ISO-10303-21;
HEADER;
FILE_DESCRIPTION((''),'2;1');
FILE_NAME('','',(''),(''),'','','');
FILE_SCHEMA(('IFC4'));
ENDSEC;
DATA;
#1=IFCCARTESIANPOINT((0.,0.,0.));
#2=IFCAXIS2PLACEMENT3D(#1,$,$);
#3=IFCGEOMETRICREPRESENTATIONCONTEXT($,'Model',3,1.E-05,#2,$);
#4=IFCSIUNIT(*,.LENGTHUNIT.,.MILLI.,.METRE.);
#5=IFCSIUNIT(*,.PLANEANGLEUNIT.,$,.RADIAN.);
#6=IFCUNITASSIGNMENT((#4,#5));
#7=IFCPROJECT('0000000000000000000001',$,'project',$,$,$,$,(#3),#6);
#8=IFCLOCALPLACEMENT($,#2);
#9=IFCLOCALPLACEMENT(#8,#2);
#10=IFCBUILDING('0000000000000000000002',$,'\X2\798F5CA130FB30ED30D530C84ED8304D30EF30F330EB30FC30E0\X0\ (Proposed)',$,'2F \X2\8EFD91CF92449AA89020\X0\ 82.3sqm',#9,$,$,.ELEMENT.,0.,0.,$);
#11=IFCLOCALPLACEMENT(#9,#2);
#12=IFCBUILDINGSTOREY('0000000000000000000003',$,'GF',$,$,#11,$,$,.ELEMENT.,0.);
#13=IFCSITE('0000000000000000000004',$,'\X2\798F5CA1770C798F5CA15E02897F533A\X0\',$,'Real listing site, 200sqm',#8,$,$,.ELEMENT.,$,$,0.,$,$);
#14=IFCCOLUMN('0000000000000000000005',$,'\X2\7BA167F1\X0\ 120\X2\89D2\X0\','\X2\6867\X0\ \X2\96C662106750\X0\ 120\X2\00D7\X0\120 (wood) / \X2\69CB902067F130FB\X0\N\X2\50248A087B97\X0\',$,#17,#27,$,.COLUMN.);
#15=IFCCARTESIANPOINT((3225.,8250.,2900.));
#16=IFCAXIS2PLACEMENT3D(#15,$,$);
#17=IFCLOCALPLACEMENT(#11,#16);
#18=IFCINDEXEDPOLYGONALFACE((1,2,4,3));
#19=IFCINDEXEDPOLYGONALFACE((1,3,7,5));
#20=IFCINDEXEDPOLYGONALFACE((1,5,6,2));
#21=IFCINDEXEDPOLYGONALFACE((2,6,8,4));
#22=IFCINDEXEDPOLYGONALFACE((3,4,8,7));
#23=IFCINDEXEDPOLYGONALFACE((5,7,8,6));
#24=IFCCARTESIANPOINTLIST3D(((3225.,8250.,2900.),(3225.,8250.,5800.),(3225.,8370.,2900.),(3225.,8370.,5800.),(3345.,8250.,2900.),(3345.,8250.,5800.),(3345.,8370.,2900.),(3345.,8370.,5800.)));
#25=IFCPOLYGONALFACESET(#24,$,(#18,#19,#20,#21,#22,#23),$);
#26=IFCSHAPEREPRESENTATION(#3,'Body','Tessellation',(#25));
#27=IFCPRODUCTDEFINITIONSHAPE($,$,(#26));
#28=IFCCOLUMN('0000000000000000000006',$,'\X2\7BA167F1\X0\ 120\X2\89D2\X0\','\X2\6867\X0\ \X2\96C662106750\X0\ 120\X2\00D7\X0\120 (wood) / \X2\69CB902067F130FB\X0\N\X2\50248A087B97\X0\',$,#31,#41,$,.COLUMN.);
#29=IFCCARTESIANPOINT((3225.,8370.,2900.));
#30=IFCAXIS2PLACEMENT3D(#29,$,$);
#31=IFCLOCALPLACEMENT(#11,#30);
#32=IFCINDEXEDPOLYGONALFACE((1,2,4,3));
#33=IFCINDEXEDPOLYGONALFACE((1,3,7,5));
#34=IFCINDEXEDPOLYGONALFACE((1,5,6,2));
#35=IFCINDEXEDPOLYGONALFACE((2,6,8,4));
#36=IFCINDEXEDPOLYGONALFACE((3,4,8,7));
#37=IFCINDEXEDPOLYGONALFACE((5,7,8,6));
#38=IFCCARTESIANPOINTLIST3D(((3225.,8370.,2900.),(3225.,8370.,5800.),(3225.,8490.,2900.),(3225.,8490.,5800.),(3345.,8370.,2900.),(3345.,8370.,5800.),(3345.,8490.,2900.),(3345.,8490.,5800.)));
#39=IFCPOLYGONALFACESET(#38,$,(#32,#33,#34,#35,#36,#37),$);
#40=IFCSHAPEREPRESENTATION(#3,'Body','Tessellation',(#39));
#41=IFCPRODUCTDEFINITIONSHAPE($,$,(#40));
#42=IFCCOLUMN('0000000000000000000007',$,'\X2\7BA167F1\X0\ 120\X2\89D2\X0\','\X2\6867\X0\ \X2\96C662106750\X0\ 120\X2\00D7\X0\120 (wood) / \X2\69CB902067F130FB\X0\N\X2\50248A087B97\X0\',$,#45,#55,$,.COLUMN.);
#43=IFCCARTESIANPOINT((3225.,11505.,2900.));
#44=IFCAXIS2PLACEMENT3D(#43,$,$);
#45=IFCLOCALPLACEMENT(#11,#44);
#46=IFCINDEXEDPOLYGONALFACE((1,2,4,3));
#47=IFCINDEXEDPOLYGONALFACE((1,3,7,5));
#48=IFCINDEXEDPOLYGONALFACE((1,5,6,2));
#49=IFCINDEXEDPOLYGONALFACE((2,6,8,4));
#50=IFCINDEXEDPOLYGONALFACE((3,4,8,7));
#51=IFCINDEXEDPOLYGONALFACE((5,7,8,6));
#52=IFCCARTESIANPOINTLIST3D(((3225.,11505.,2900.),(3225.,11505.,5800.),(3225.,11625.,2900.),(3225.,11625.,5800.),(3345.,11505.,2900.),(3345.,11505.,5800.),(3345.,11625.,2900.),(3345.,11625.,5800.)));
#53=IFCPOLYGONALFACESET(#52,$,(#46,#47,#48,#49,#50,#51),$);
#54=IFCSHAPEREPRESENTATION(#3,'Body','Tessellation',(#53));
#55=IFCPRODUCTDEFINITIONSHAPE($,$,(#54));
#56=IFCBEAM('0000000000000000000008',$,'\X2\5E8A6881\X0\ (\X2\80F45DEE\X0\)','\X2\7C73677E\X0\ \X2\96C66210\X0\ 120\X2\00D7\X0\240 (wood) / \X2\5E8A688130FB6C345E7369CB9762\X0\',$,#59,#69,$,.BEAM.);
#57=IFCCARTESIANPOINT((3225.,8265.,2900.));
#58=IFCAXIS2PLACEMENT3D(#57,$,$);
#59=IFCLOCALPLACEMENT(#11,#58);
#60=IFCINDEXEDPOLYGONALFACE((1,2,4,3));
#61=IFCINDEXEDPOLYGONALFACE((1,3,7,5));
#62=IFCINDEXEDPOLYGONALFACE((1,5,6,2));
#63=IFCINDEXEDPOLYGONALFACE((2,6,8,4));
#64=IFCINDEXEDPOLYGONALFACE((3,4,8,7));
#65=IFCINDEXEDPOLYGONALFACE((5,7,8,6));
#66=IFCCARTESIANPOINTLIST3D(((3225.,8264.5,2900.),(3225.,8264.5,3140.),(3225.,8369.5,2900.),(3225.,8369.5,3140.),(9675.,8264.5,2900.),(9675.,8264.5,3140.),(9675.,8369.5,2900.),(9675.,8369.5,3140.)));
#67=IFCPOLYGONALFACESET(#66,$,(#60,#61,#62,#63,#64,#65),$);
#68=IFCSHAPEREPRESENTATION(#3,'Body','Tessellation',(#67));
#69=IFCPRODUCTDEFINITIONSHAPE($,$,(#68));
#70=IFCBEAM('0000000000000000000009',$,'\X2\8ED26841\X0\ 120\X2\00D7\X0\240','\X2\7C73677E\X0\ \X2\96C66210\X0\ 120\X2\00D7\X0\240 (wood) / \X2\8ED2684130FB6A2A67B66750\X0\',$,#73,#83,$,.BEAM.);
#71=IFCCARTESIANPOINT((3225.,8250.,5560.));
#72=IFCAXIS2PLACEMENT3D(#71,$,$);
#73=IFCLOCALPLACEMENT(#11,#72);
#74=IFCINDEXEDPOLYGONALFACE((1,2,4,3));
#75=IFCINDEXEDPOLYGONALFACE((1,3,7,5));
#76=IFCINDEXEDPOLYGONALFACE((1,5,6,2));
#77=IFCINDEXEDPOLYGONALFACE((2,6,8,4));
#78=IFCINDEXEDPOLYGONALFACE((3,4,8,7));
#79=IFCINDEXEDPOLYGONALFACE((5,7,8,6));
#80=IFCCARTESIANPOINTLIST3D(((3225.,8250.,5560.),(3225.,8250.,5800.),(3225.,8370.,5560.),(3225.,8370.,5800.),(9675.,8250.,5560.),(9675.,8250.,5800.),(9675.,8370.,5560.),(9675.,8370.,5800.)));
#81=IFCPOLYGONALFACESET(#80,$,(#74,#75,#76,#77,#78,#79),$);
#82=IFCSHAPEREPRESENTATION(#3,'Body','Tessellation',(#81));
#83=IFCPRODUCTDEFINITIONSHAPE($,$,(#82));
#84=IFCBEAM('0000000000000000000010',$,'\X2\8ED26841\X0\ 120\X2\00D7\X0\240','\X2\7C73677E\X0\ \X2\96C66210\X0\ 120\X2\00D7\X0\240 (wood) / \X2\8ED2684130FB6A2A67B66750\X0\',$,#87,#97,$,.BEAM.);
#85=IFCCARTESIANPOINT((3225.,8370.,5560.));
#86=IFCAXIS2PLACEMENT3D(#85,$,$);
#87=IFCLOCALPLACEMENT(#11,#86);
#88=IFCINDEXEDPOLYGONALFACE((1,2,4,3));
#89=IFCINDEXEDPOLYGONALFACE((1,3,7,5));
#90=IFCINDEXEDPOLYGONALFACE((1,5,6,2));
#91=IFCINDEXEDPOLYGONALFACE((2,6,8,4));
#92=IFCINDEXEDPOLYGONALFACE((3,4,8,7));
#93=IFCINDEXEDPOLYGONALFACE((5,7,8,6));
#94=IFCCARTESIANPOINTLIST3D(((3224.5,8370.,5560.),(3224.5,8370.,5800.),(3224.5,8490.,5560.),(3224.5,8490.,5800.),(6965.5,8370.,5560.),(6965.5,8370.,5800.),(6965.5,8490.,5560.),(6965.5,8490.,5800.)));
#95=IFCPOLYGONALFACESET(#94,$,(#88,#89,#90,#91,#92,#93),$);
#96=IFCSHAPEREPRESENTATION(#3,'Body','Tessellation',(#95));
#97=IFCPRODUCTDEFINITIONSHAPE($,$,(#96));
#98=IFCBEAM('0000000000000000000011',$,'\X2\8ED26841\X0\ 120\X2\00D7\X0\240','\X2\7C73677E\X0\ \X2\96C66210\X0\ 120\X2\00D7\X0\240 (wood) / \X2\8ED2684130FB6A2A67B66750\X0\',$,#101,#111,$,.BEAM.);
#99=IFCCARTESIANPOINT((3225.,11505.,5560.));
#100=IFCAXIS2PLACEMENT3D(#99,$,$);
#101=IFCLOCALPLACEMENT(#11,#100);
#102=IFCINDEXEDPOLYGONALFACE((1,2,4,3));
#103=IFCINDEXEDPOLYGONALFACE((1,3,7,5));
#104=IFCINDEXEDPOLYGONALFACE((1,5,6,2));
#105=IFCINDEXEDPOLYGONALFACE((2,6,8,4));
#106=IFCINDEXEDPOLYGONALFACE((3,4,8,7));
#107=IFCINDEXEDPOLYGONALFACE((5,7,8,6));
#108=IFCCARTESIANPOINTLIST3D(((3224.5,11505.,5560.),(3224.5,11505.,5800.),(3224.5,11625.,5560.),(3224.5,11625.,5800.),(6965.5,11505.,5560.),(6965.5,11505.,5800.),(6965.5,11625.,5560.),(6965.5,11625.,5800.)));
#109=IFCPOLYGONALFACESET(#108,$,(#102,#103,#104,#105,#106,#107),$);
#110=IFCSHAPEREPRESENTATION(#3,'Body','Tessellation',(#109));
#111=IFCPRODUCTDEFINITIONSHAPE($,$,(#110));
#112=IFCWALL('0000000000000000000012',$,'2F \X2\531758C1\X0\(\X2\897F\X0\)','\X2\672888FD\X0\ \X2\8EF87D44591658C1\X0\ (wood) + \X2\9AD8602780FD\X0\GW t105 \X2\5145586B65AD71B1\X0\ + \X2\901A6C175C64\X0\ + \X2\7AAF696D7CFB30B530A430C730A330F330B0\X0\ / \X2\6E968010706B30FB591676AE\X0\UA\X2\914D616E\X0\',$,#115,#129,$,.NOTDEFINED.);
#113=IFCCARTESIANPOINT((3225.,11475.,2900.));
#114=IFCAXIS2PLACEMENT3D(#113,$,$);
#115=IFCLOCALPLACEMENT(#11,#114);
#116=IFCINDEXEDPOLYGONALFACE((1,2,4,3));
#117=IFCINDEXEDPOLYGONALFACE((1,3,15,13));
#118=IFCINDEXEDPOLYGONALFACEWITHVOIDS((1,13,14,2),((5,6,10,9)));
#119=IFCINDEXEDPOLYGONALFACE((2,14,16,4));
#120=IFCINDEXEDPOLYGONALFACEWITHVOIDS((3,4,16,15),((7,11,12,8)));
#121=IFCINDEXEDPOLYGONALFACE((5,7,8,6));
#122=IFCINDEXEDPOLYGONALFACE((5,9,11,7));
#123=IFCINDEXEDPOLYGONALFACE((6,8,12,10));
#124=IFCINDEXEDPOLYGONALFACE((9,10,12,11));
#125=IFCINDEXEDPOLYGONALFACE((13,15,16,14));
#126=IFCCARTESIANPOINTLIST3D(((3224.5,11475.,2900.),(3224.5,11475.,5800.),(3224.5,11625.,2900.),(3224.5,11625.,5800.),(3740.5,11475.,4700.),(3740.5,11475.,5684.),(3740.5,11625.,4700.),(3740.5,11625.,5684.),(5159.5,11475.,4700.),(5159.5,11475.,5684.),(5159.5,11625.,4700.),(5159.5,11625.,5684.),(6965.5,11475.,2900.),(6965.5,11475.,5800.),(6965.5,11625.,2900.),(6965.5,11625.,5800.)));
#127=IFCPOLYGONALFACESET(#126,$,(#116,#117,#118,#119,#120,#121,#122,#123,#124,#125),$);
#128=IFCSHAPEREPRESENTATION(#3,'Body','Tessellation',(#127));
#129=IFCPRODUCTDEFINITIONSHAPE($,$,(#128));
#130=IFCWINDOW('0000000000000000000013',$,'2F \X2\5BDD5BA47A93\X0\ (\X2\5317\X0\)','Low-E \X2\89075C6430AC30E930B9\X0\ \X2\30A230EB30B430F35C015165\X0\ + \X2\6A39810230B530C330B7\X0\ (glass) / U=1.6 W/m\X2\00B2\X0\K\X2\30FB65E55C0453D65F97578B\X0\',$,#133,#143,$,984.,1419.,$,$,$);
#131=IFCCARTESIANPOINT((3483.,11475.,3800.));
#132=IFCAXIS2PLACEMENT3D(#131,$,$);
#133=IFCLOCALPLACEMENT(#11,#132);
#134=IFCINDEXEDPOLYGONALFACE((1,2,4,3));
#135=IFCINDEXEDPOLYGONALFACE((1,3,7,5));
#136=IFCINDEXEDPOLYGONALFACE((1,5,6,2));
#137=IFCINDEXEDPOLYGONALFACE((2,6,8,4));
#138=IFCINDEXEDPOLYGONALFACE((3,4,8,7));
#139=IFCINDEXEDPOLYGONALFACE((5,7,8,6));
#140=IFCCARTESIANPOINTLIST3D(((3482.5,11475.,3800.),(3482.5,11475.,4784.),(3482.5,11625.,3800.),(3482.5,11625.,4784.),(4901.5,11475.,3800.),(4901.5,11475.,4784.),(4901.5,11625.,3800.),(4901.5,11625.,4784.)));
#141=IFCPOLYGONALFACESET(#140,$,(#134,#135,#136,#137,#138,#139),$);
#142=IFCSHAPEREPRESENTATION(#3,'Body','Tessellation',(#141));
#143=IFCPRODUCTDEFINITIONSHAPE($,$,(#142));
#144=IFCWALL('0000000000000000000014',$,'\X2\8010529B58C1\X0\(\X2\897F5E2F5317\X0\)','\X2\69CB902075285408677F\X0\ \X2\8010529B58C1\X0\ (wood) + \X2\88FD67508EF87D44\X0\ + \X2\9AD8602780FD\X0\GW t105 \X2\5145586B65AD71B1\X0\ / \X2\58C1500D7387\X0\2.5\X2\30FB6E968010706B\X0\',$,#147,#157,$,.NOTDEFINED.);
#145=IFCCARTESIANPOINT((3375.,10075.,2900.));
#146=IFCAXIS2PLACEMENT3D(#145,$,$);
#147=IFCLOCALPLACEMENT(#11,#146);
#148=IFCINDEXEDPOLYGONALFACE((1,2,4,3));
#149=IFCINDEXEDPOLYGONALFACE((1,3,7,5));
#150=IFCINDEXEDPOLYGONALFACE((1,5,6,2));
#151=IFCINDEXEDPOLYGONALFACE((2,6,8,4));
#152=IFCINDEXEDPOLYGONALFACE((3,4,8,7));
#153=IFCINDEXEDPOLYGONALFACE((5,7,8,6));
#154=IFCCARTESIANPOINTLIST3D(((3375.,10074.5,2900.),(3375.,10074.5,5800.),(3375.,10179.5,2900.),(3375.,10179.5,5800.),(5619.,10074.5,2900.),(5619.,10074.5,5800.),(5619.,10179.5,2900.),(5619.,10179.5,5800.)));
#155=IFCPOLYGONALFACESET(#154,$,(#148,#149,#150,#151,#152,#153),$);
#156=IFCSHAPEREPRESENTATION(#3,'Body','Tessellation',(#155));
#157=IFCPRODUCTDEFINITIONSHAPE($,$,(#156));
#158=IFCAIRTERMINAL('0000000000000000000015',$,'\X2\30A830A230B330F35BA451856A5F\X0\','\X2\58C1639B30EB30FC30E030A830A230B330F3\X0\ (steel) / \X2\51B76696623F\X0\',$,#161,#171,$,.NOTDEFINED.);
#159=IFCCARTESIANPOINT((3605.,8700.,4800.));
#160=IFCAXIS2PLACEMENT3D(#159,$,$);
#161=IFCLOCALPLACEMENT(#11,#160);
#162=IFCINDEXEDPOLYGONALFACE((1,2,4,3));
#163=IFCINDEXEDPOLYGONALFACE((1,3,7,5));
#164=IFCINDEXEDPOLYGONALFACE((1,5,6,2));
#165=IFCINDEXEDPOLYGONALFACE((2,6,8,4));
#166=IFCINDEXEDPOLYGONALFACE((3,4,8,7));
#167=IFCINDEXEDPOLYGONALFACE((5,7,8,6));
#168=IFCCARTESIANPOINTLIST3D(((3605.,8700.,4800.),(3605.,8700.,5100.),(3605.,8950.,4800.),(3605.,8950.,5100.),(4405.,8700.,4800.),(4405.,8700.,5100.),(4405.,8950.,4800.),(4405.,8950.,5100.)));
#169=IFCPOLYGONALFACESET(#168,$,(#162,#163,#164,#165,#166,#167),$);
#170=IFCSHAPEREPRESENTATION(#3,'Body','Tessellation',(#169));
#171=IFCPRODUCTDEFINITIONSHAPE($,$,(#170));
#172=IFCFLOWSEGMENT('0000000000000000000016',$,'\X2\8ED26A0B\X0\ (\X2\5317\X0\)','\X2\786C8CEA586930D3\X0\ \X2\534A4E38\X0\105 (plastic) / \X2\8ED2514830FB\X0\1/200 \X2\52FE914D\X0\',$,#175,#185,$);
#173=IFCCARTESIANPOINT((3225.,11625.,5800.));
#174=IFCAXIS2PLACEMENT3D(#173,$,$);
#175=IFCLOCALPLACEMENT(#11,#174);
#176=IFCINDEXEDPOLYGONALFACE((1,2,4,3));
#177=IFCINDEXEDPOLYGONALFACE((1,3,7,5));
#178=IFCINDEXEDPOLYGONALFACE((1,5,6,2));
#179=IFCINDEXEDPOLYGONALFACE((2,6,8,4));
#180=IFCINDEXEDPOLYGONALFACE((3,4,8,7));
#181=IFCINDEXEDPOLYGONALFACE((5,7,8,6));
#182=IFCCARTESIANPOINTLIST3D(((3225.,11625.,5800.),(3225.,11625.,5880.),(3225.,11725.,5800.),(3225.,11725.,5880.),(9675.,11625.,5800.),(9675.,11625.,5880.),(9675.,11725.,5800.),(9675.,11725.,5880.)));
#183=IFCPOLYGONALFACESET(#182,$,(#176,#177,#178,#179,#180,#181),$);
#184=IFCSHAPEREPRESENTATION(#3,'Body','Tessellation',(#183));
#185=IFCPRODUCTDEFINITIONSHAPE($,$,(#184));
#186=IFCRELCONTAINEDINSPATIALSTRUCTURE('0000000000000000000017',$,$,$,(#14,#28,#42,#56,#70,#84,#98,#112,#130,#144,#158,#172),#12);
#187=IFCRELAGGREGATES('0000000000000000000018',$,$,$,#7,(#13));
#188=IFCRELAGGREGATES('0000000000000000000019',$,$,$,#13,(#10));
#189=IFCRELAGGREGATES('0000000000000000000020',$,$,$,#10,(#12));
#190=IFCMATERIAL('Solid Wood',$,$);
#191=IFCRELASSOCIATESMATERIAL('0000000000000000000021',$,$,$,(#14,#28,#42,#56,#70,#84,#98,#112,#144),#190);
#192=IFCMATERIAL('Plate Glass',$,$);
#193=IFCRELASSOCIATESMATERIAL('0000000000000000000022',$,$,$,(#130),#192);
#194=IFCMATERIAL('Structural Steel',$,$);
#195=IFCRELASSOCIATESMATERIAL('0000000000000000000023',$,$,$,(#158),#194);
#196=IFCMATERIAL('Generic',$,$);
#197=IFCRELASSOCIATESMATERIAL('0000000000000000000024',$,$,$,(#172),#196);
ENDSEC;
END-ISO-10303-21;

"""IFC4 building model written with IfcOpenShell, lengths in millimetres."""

from ifc_helpers import new_model, si_unit, frame, frame_2d, origin, place, context, project, spatial, rectangle, extrude, material, element, fill, save


model = new_model("IFC4")

# Units and contexts
model_context = context("Model", 3, precision=1e-05, world=origin())
ifc_project = project(units=[si_unit("LENGTHUNIT", "METRE", prefix="MILLI"), si_unit("PLANEANGLEUNIT", "RADIAN")], contexts=[model_context])

# Site, building, storey
site_placement = place(None, origin())
site = spatial("IfcSite", under=ifc_project, at=site_placement, Name="福岡県福岡市西区", ObjectType="Real listing site, 200sqm", CompositionType="ELEMENT", RefElevation=0.0)
building_placement = place(site_placement, origin())
building = spatial("IfcBuilding", under=site, at=building_placement, Name="福岡・ロフト付きワンルーム (Proposed)", ObjectType="2F 軽量鉄骨造 82.3sqm", CompositionType="ELEMENT", ElevationOfRefHeight=0.0, ElevationOfTerrain=0.0)
storey_placement = place(building_placement, origin())
storey = spatial("IfcBuildingStorey", under=building, at=storey_placement, Name="GF", CompositionType="ELEMENT", Elevation=0.0)

# Columns
ifc_material_1 = material(Name="Solid Wood")
column_1_placement = place(storey_placement, frame((3225.0, 8250.0, 2900.0)))
element("IfcColumn", 1, at=column_1_placement, inside=storey, material=ifc_material_1, Name="管柱 120角", Description="桧 集成材 120×120 (wood) / 構造柱・N値計算", PredefinedType="COLUMN", context=model_context, shape_type="SweptSolid", body=[
    extrude(rectangle(XDim=120.0, YDim=120.0, at=frame_2d((60.0, 60.0))), frame((3225.0, 8250.0, 2900.0)), (0.0, 0.0, 1.0), 2900.0),
])
column_2_placement = place(storey_placement, frame((3225.0, 8370.0, 2900.0)))
element("IfcColumn", 2, at=column_2_placement, inside=storey, material=ifc_material_1, Name="管柱 120角", Description="桧 集成材 120×120 (wood) / 構造柱・N値計算", PredefinedType="COLUMN", context=model_context, shape_type="SweptSolid", body=[
    extrude(rectangle(XDim=120.0, YDim=120.0, at=frame_2d((60.0, 60.0))), frame((3225.0, 8370.0, 2900.0)), (0.0, 0.0, 1.0), 2900.0),
])
column_3_placement = place(storey_placement, frame((3225.0, 11505.0, 2900.0)))
element("IfcColumn", 3, at=column_3_placement, inside=storey, material=ifc_material_1, Name="管柱 120角", Description="桧 集成材 120×120 (wood) / 構造柱・N値計算", PredefinedType="COLUMN", context=model_context, shape_type="SweptSolid", body=[
    extrude(rectangle(XDim=120.0, YDim=120.0, at=frame_2d((60.0, 60.0))), frame((3225.0, 11505.0, 2900.0)), (0.0, 0.0, 1.0), 2900.0),
])

# Beams
beam_1_placement = place(storey_placement, frame((3225.0, 8265.0, 2900.0)))
element("IfcBeam", 4, at=beam_1_placement, inside=storey, material=ifc_material_1, Name="床梁 (胴差)", Description="米松 集成 120×240 (wood) / 床梁・水平構面", PredefinedType="BEAM", context=model_context, shape_type="SweptSolid", body=[
    extrude(rectangle(XDim=6450.0, YDim=105.0, at=frame_2d((3225.0, 52.0))), frame((3225.0, 8265.0, 2900.0)), (0.0, 0.0, 1.0), 240.0),
])
beam_2_placement = place(storey_placement, frame((3225.0, 8250.0, 5560.0)))
element("IfcBeam", 5, at=beam_2_placement, inside=storey, material=ifc_material_1, Name="軒桁 120×240", Description="米松 集成 120×240 (wood) / 軒桁・横架材", PredefinedType="BEAM", context=model_context, shape_type="SweptSolid", body=[
    extrude(rectangle(XDim=6450.0, YDim=120.0, at=frame_2d((3225.0, 60.0))), frame((3225.0, 8250.0, 5560.0)), (0.0, 0.0, 1.0), 240.0),
])
beam_3_placement = place(storey_placement, frame((3225.0, 8370.0, 5560.0)))
element("IfcBeam", 6, at=beam_3_placement, inside=storey, material=ifc_material_1, Name="軒桁 120×240", Description="米松 集成 120×240 (wood) / 軒桁・横架材", PredefinedType="BEAM", context=model_context, shape_type="SweptSolid", body=[
    extrude(rectangle(XDim=3741.0, YDim=120.0, at=frame_2d((1870.0, 60.0))), frame((3225.0, 8370.0, 5560.0)), (0.0, 0.0, 1.0), 240.0),
])
beam_4_placement = place(storey_placement, frame((3225.0, 11505.0, 5560.0)))
element("IfcBeam", 7, at=beam_4_placement, inside=storey, material=ifc_material_1, Name="軒桁 120×240", Description="米松 集成 120×240 (wood) / 軒桁・横架材", PredefinedType="BEAM", context=model_context, shape_type="SweptSolid", body=[
    extrude(rectangle(XDim=3741.0, YDim=120.0, at=frame_2d((1870.0, 60.0))), frame((3225.0, 11505.0, 5560.0)), (0.0, 0.0, 1.0), 240.0),
])

# Wall, opening, window
wall_1_placement = place(storey_placement, frame((3225.0, 11475.0, 2900.0)))
wall_1 = element("IfcWall", 8, at=wall_1_placement, inside=storey, material=ifc_material_1, Name="2F 北壁(西)", Description="木製 軸組外壁 (wood) + 高性能GW t105 充填断熱 + 通気層 + 窯業系サイディング / 準耐火・外皮UA配慮", PredefinedType="NOTDEFINED", context=model_context, shape_type="SweptSolid", body=[
    extrude(rectangle(XDim=3741.0, YDim=150.0, at=frame_2d((1870.0, 75.0))), frame((3225.0, 11475.0, 2900.0)), (0.0, 0.0, 1.0), 2900.0),
])
opening_placement = place(storey_placement, frame((3483.0, 11475.0, 3800.0)))
opening = element("IfcOpeningElement", 9, at=opening_placement, cuts=wall_1, PredefinedType="NOTDEFINED", context=model_context, shape_type="SweptSolid", body=[
    extrude(rectangle(XDim=1419.0, YDim=150.0, at=frame_2d((709.0, 75.0))), frame((3483.0, 11475.0, 3800.0)), (0.0, 0.0, 1.0), 984.0),
])
ifc_material_2 = material(Name="Plate Glass")
window_placement = place(storey_placement, frame((3483.0, 11475.0, 3800.0)))
window = element("IfcWindow", 10, at=window_placement, inside=storey, material=ifc_material_2, Name="2F 寝室窓 (北)", Description="Low-E 複層ガラス アルゴン封入 + 樹脂サッシ (glass) / U=1.6 W/m²K・日射取得型", OverallHeight=984.0, OverallWidth=1419.0, context=model_context, shape_type="SweptSolid", body=[
    extrude(rectangle(XDim=1419.0, YDim=150.0, at=frame_2d((709.0, 75.0))), frame((3483.0, 11475.0, 3800.0)), (0.0, 0.0, 1.0), 984.0),
])
fill(opening, window)

# Wall
wall_2_placement = place(storey_placement, frame((3375.0, 10075.0, 2900.0)))
element("IfcWall", 11, at=wall_2_placement, inside=storey, material=ifc_material_1, Name="耐力壁(西帯北)", Description="構造用合板 耐力壁 (wood) + 製材軸組 + 高性能GW t105 充填断熱 / 壁倍率2.5・準耐火", PredefinedType="NOTDEFINED", context=model_context, shape_type="SweptSolid", body=[
    extrude(rectangle(XDim=2244.0, YDim=105.0, at=frame_2d((1122.0, 52.0))), frame((3375.0, 10075.0, 2900.0)), (0.0, 0.0, 1.0), 2900.0),
])

# Shared definitions
ifc_material_3 = material(Name="Structural Steel")

# Shared definitions
ifc_material_4 = material(Name="Generic")

# Air terminal
air_terminal_placement = place(storey_placement, frame((3605.0, 8700.0, 4800.0)))
element("IfcAirTerminal", 12, at=air_terminal_placement, inside=storey, material=ifc_material_3, Name="エアコン室内機", Description="壁掛ルームエアコン (steel) / 冷暖房", PredefinedType="NOTDEFINED", context=model_context, shape_type="SweptSolid", body=[
    extrude(rectangle(XDim=800.0, YDim=250.0, at=frame_2d((400.0, 125.0))), frame((3605.0, 8700.0, 4800.0)), (0.0, 0.0, 1.0), 300.0),
])

# Flow segment
flow_segment_placement = place(storey_placement, frame((3225.0, 11625.0, 5800.0)))
element("IfcFlowSegment", 13, at=flow_segment_placement, inside=storey, material=ifc_material_4, Name="軒樋 (北)", Description="硬質塩ビ 半丸105 (plastic) / 軒先・1/200 勾配", context=model_context, shape_type="SweptSolid", body=[
    extrude(rectangle(XDim=6450.0, YDim=100.0, at=frame_2d((3225.0, 50.0))), frame((3225.0, 11625.0, 5800.0)), (0.0, 0.0, 1.0), 80.0),
])

save(model, "model.ifc")
